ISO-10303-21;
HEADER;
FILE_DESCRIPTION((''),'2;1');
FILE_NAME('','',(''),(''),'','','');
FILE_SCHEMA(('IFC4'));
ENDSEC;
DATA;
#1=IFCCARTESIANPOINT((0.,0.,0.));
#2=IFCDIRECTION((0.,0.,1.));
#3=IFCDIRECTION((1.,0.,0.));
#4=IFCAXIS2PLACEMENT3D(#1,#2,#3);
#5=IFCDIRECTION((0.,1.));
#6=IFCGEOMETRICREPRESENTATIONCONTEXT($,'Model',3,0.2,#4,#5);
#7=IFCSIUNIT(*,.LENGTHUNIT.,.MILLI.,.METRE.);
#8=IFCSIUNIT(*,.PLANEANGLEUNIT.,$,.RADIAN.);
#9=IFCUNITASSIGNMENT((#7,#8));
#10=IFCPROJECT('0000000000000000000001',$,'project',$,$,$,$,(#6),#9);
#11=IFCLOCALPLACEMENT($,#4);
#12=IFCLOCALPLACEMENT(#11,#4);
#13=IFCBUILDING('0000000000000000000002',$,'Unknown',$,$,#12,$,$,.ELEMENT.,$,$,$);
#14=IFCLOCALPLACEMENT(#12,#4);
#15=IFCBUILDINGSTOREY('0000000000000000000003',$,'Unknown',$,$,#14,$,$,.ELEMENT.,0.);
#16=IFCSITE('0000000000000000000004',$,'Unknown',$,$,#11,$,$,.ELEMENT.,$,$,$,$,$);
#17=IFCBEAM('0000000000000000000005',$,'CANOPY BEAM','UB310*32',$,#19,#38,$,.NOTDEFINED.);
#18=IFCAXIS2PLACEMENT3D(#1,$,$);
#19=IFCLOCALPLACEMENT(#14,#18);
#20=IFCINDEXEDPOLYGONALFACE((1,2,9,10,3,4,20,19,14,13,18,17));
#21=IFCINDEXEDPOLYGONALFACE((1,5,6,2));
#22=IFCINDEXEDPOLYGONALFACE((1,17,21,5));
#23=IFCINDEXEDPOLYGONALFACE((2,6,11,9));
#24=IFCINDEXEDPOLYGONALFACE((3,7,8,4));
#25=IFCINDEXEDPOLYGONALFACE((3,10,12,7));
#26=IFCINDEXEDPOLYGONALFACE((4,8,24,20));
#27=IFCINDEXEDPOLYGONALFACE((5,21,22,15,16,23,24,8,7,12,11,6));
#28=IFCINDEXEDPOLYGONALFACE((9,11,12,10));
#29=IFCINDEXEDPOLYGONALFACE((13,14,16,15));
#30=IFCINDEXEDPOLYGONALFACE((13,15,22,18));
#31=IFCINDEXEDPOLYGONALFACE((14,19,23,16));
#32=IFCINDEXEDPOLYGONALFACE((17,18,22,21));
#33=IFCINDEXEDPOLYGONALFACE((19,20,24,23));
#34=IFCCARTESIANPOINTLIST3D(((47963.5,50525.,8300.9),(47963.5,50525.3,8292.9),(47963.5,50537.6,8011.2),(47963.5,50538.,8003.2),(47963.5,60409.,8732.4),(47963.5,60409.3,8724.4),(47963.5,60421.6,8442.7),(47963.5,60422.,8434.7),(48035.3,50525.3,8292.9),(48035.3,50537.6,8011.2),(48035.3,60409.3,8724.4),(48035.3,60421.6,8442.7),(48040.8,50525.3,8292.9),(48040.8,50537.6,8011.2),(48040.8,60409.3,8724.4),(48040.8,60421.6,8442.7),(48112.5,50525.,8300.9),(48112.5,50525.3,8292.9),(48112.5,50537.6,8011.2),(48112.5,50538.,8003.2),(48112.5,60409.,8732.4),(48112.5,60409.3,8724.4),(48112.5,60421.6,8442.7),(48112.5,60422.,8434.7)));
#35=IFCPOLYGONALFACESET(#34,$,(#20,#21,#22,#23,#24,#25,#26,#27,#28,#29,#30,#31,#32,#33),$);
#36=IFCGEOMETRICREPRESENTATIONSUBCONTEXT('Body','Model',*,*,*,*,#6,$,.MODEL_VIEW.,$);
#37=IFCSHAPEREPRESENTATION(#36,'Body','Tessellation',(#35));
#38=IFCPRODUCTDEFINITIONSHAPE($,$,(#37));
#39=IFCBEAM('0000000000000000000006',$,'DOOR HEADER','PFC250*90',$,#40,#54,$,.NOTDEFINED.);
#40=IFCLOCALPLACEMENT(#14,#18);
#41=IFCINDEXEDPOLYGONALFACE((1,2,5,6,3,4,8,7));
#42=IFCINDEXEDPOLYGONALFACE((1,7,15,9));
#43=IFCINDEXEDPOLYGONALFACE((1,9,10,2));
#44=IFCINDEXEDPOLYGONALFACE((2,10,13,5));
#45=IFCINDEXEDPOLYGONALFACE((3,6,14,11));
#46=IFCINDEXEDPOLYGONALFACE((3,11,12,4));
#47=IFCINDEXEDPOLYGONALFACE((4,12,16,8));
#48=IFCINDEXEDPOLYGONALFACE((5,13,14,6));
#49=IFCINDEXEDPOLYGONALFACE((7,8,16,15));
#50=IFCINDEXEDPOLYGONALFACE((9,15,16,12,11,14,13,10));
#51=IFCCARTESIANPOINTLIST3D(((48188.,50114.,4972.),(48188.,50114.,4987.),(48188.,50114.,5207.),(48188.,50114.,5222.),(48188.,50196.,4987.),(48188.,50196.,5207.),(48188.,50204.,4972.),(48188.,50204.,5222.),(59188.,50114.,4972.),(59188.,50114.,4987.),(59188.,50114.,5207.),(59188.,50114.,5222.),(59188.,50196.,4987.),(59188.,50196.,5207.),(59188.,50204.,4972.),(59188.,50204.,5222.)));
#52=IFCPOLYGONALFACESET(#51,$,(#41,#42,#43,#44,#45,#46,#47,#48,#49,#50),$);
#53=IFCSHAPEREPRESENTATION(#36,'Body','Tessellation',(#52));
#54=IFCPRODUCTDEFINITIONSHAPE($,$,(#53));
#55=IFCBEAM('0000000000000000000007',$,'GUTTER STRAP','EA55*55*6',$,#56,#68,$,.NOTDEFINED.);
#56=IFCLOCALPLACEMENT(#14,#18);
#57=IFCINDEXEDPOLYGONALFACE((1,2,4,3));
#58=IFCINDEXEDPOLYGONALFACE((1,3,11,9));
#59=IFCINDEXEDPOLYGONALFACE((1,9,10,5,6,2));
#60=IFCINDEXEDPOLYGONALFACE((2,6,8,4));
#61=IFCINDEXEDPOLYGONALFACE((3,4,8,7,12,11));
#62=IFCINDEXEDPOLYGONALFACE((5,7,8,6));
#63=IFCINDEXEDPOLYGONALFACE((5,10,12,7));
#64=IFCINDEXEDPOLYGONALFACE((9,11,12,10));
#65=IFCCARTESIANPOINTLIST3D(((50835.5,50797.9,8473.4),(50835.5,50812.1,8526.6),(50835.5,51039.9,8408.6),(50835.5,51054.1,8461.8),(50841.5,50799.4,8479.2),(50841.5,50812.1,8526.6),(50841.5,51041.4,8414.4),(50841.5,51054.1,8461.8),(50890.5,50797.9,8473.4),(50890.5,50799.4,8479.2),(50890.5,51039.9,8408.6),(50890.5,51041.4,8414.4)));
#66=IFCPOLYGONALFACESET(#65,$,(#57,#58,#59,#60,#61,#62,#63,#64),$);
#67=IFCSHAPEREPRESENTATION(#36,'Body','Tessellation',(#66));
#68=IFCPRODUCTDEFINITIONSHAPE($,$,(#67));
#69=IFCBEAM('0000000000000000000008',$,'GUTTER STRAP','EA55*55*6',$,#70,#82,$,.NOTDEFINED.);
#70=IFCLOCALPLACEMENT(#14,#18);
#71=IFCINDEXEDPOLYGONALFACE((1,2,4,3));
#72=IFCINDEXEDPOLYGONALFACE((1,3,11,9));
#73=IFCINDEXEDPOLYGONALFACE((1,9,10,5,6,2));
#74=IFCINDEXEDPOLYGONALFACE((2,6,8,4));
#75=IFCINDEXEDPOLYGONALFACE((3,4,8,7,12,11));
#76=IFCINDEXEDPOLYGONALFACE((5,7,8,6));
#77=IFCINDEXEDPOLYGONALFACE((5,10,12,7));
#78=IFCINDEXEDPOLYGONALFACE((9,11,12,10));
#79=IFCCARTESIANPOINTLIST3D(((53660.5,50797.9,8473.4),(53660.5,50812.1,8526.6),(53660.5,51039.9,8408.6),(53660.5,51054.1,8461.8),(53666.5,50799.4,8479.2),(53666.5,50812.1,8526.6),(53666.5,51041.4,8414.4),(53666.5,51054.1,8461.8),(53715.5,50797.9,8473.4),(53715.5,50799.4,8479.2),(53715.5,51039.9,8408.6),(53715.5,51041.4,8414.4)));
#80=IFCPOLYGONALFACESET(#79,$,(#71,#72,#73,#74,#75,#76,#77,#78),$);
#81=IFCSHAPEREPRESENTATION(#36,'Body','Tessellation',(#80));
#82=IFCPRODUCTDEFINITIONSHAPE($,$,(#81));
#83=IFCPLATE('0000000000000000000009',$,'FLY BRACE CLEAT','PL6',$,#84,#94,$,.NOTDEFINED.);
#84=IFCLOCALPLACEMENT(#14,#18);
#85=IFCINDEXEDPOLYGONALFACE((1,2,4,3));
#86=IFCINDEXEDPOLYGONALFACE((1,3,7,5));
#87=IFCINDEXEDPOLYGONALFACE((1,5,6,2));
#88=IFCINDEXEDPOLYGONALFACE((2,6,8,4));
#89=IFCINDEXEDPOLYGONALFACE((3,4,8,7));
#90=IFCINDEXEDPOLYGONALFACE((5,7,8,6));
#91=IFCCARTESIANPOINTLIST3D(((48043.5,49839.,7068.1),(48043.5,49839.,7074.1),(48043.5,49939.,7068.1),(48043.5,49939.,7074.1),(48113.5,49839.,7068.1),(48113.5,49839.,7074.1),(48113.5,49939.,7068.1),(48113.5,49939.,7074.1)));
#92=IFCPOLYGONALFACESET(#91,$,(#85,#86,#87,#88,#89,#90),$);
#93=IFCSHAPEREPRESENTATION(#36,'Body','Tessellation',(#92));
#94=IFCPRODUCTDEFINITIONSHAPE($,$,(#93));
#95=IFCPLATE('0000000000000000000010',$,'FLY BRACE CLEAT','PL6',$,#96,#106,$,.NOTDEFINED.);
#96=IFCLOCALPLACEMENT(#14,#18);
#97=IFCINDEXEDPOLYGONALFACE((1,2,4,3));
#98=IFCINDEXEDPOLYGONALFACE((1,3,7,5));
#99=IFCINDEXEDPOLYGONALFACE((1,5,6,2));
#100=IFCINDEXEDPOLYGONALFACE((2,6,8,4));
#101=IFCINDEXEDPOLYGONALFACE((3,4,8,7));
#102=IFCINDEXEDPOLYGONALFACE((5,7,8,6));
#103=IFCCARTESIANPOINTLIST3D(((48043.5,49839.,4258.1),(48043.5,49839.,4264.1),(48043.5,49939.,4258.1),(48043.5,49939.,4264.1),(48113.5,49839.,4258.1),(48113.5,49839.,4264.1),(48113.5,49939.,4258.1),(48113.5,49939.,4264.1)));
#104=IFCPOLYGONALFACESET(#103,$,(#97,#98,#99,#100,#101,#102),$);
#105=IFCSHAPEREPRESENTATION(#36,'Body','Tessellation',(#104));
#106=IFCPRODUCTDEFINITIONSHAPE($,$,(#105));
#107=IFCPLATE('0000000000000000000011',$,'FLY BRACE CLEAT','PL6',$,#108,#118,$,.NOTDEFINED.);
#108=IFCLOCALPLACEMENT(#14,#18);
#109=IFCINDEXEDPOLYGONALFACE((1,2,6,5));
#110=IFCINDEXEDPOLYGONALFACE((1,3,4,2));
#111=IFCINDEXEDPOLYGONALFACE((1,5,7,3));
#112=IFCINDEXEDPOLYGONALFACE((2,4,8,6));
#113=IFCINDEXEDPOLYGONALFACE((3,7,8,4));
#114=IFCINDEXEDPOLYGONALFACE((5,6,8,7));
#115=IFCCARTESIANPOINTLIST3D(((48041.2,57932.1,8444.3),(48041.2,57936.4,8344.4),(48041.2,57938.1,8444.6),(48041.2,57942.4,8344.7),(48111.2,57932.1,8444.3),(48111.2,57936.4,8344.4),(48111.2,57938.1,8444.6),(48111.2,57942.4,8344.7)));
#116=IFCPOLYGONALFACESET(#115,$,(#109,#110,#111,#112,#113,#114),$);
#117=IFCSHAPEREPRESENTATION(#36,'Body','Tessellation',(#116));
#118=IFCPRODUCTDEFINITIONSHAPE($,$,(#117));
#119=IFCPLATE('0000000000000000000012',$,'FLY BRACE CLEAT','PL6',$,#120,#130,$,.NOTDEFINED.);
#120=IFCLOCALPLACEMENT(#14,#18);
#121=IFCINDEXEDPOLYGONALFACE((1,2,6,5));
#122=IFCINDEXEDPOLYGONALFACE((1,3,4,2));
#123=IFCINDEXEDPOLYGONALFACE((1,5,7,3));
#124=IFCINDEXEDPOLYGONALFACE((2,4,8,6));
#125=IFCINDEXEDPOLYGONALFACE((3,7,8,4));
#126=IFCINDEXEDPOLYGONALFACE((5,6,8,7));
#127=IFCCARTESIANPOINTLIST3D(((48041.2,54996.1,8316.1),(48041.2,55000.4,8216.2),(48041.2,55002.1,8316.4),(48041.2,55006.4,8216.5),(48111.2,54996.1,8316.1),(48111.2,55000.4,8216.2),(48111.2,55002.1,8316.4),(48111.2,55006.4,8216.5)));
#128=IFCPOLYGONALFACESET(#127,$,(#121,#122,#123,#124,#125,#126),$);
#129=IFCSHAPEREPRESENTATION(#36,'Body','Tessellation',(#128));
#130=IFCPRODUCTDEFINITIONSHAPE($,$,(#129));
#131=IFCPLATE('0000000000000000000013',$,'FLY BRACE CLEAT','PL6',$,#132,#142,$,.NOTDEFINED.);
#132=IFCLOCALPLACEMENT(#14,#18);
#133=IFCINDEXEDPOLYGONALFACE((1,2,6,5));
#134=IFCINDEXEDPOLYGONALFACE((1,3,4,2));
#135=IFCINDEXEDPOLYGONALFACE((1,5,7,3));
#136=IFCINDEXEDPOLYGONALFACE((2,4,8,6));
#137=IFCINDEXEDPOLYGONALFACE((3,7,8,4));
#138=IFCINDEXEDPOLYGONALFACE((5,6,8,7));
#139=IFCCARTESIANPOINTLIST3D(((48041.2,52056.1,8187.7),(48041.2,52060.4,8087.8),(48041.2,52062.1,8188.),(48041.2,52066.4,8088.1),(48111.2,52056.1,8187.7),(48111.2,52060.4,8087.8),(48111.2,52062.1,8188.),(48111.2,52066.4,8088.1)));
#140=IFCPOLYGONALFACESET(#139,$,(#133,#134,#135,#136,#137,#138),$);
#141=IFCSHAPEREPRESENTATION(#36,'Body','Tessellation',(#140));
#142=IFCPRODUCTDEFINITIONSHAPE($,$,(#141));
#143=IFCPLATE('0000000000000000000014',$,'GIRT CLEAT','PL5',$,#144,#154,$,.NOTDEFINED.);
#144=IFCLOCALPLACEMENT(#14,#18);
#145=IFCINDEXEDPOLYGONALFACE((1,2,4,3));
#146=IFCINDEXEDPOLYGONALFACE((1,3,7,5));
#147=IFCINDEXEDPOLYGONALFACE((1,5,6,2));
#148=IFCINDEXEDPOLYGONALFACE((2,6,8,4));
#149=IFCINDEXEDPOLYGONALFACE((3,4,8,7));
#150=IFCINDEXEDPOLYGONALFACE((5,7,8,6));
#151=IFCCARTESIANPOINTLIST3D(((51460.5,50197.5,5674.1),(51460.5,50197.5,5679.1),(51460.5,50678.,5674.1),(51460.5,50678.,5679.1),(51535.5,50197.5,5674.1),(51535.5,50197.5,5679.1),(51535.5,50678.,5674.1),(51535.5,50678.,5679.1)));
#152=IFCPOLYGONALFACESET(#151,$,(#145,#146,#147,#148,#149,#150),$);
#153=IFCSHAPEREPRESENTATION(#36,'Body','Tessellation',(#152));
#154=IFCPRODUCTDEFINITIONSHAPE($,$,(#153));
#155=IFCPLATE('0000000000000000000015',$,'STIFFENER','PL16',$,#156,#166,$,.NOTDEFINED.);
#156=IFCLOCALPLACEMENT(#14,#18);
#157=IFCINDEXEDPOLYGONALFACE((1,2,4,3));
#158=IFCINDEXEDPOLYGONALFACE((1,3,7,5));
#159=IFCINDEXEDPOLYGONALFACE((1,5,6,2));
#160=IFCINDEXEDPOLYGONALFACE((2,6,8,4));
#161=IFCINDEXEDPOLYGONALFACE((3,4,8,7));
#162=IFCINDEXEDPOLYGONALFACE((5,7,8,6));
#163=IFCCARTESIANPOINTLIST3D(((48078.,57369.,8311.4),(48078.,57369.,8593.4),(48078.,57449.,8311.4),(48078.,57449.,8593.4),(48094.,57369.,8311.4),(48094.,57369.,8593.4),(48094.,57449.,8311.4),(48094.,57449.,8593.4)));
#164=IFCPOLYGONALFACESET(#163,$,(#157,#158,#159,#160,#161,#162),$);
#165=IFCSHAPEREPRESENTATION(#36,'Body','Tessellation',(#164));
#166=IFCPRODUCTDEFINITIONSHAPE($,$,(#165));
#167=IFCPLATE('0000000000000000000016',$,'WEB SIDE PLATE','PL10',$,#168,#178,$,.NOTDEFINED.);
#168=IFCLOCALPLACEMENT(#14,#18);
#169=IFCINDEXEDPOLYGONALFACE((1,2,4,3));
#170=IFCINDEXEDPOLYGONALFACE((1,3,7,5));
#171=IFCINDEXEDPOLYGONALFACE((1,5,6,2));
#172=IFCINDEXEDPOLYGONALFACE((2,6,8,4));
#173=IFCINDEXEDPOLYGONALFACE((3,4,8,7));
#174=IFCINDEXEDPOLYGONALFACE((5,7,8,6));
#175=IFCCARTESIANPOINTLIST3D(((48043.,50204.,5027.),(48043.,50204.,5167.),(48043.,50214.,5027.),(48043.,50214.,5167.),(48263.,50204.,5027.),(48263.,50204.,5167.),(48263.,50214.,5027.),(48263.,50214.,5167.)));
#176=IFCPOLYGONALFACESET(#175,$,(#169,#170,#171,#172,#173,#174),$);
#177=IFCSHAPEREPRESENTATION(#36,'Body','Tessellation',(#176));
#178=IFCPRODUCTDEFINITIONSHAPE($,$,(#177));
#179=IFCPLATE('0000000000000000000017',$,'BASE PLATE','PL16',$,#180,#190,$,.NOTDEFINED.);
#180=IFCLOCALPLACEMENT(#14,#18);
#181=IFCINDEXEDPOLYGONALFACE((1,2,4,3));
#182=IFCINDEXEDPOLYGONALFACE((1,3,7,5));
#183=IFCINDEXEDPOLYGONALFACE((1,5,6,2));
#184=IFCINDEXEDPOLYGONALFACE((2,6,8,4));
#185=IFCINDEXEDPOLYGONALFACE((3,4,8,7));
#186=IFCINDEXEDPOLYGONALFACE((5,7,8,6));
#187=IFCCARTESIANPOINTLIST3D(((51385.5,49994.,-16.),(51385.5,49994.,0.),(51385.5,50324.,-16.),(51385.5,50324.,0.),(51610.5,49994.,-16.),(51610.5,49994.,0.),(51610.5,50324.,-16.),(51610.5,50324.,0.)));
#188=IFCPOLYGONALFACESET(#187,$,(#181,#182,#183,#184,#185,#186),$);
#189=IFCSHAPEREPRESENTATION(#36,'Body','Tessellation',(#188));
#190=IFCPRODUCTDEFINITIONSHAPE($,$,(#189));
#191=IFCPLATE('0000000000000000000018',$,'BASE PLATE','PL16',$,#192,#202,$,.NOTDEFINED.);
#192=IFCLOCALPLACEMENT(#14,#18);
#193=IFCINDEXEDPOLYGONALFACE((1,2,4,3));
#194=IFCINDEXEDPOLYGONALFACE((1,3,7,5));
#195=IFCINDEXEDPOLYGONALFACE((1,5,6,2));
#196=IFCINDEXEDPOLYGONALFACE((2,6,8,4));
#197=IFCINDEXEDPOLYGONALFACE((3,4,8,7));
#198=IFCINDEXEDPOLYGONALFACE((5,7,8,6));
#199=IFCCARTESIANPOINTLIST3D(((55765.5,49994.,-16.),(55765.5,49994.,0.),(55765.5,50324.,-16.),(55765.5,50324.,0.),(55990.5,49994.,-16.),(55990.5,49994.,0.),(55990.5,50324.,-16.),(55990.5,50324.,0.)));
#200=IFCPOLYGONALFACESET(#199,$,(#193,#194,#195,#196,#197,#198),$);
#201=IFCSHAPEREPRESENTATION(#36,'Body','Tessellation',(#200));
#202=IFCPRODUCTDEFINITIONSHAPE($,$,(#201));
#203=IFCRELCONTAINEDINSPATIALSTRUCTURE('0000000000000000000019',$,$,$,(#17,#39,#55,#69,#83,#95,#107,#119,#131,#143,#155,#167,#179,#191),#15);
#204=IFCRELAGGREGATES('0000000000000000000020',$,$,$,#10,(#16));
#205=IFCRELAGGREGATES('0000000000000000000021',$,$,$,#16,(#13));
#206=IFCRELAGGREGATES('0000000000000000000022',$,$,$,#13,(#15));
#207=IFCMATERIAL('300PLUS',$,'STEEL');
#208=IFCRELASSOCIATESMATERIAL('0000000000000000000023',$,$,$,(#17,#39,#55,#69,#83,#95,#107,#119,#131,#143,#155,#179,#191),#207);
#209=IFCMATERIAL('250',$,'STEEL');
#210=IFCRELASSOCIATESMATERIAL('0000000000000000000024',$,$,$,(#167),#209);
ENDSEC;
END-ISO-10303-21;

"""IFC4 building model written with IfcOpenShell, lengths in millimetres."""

from ifc_helpers import new_model, si_unit, direction, frame, origin_with_axes, place, context, subcontext, project, spatial, line, indexed_curve, outline, extrude, material, element, save


model = new_model("IFC4")

# Units and contexts
model_context = context("Model", 3, precision=0.2, world=origin_with_axes(), true_north=direction((0.0, 1.0)))
body_context = subcontext(model_context, "Body", "Model", "MODEL_VIEW")
ifc_project = project(units=[si_unit("LENGTHUNIT", "METRE", prefix="MILLI"), si_unit("PLANEANGLEUNIT", "RADIAN")], contexts=[model_context])

# Site, building, storey
site_placement = place(None, origin_with_axes())
site = spatial("IfcSite", under=ifc_project, at=site_placement, Name="Unknown", CompositionType="ELEMENT")
building_placement = place(site_placement, origin_with_axes())
building = spatial("IfcBuilding", under=site, at=building_placement, Name="Unknown", CompositionType="ELEMENT")
storey_placement = place(building_placement, origin_with_axes())
storey = spatial("IfcBuildingStorey", under=building, at=storey_placement, Name="Unknown", CompositionType="ELEMENT", Elevation=0.0)

# Shared definitions
ifc_material_1 = material(Name="300PLUS", Category="STEEL")

# Beams
beam_1_placement = place(storey_placement, frame((48038.0, 50531.5, 8152.0), z_axis=(1.0, 0.0, 0.0), x_axis=(0.0, 0.999048, 0.043615)))
element("IfcBeam", 1, at=beam_1_placement, inside=storey, material=ifc_material_1, Name="CANOPY BEAM", Description="UB310*32", PredefinedType="NOTDEFINED", context=body_context, shape_type="SolidModel", body=[
    extrude(outline(indexed_curve([(-74.5, -149.0), (74.5, -149.0), (74.5, -141.0), (2.8, -141.0), (2.8, 141.0), (74.5, 141.0), (74.5, 149.0), (-74.5, 149.0), (-74.5, 141.0), (-2.8, 141.0), (-2.8, -141.0), (-74.5, -141.0)], segments=[line(1, 2, 3, 4, 5, 6, 7, 8, 9, 10, 11, 12, 1)])), frame((0.0, 0.0, 0.0), z_axis=(-1.0, 0.0, 0.0), x_axis=(0.0, 0.0, 1.0)), (0.0, 0.0, -1.0), 9893.4),
])
beam_2_placement = place(storey_placement, frame((48188.0, 50159.0, 5097.0), z_axis=(0.0, -1.0, 0.0), x_axis=(1.0, 0.0, 0.0)))
element("IfcBeam", 2, at=beam_2_placement, inside=storey, material=ifc_material_1, Name="DOOR HEADER", Description="PFC250*90", PredefinedType="NOTDEFINED", context=body_context, shape_type="SolidModel", body=[
    extrude(outline(indexed_curve([(-45.0, -125.0), (45.0, -125.0), (45.0, -110.0), (-37.0, -110.0), (-37.0, 110.0), (45.0, 110.0), (45.0, 125.0), (-45.0, 125.0)], segments=[line(1, 2, 3, 4, 5, 6, 7, 8, 1)])), frame((0.0, 0.0, 0.0), z_axis=(-1.0, 0.0, 0.0), x_axis=(0.0, 0.0, 1.0)), (0.0, 0.0, -1.0), 11000.0),
])
for number, where, z_axis, x_axis, name in (
    (3, (50863.0, 51047.0, 8435.2), (0.0, 0.258656, 0.965969), (0.0, -0.965969, 0.258656), "GUTTER STRAP"),
    (4, (53688.0, 51047.0, 8435.2), (0.0, 0.258656, 0.965969), (0.0, -0.965969, 0.258656), "GUTTER STRAP"),
):
    element("IfcBeam", number, at=place(storey_placement, frame(where, z_axis=z_axis, x_axis=x_axis)), inside=storey, material=ifc_material_1, Name=name, Description="EA55*55*6", PredefinedType="NOTDEFINED", context=body_context, shape_type="SolidModel", body=[
        extrude(outline(indexed_curve([(-27.5, -27.5), (27.5, -27.5), (27.5, -21.5), (-21.5, -21.5), (-21.5, 27.5), (-27.5, 27.5)], segments=[line(1, 2, 3, 4, 5, 6, 1)])), frame((0.0, 0.0, 0.0), z_axis=(-1.0, 0.0, 0.0), x_axis=(0.0, 0.0, 1.0)), (0.0, 0.0, -1.0), 250.5),
    ])

# Plates
for number, where, z_axis, x_axis, name in (
    (5, (48113.5, 49939.0, 7071.1), (0.0, 0.0, 1.0), (-1.0, 0.0, 0.0), "FLY BRACE CLEAT"),
    (6, (48113.5, 49939.0, 4261.1), (0.0, 0.0, 1.0), (-1.0, 0.0, 0.0), "FLY BRACE CLEAT"),
):
    element("IfcPlate", number, at=place(storey_placement, frame(where, z_axis=z_axis, x_axis=x_axis)), inside=storey, material=ifc_material_1, Name=name, Description="PL6", PredefinedType="NOTDEFINED", context=body_context, shape_type="SolidModel", body=[
        extrude(outline(indexed_curve([(0.0, 0.0), (70.0, 0.0), (70.0, 100.0), (0.0, 100.0)], segments=[line(1, 2, 3, 4, 1)])), frame((0.0, 0.0, 3.0), z_axis=(0.0, 0.0, 1.0), x_axis=(1.0, 0.0, 0.0)), (0.0, 0.0, -1.0), 6.0),
    ])
for number, where, z_axis, x_axis, name in (
    (7, (48041.2, 57935.1, 8444.4), (0.0, 0.999075, 0.043003), (1.0, 0.0, 0.0), "FLY BRACE CLEAT"),
    (8, (48041.2, 54999.1, 8316.2), (0.0, 0.999075, 0.043003), (1.0, 0.0, 0.0), "FLY BRACE CLEAT"),
    (9, (48041.2, 52059.1, 8187.8), (0.0, 0.999075, 0.043003), (1.0, 0.0, 0.0), "FLY BRACE CLEAT"),
):
    element("IfcPlate", number, at=place(storey_placement, frame(where, z_axis=z_axis, x_axis=x_axis)), inside=storey, material=ifc_material_1, Name=name, Description="PL6", PredefinedType="NOTDEFINED", context=body_context, shape_type="SolidModel", body=[
        extrude(outline(indexed_curve([(0.0, 0.0), (70.0, 0.0), (70.0, 100.0), (0.0, 100.0)], segments=[line(1, 2, 3, 4, 1)])), frame((0.0, 0.0, 3.0), z_axis=(0.0, 0.0, 1.0), x_axis=(1.0, 0.0, 0.0)), (0.0, 0.0, -1.0), 6.0),
    ])
plate_1_placement = place(storey_placement, frame((51460.5, 50197.5, 5676.6), z_axis=(0.0, 0.0, 1.0), x_axis=(1.0, 0.0, 0.0)))
element("IfcPlate", 10, at=plate_1_placement, inside=storey, material=ifc_material_1, Name="GIRT CLEAT", Description="PL5", PredefinedType="NOTDEFINED", context=body_context, shape_type="SolidModel", body=[
    extrude(outline(indexed_curve([(0.0, 0.0), (75.0, 0.0), (75.0, 480.5), (0.0, 480.5)], segments=[line(1, 2, 3, 4, 1)])), frame((0.0, 0.0, 2.5), z_axis=(0.0, 0.0, 1.0), x_axis=(1.0, 0.0, 0.0)), (0.0, 0.0, -1.0), 5.0),
])
plate_2_placement = place(storey_placement, frame((48086.0, 57369.0, 8311.4), z_axis=(1.0, 0.0, 0.0), x_axis=(0.0, 1.0, 0.0)))
element("IfcPlate", 11, at=plate_2_placement, inside=storey, material=ifc_material_1, Name="STIFFENER", Description="PL16", PredefinedType="NOTDEFINED", context=body_context, shape_type="SolidModel", body=[
    extrude(outline(indexed_curve([(0.0, 0.0), (80.0, 0.0), (80.0, 282.0), (0.0, 282.0)], segments=[line(1, 2, 3, 4, 1)])), frame((0.0, 0.0, 8.0), z_axis=(0.0, 0.0, 1.0), x_axis=(1.0, 0.0, 0.0)), (0.0, 0.0, -1.0), 16.0),
])
ifc_material_2 = material(Name="250", Category="STEEL")
plate_3_placement = place(storey_placement, frame((48263.0, 50209.0, 5167.0), z_axis=(0.0, 1.0, 0.0), x_axis=(0.0, 0.0, -1.0)))
element("IfcPlate", 12, at=plate_3_placement, inside=storey, material=ifc_material_2, Name="WEB SIDE PLATE", Description="PL10", PredefinedType="NOTDEFINED", context=body_context, shape_type="SolidModel", body=[
    extrude(outline(indexed_curve([(0.0, 0.0), (140.0, 0.0), (140.0, 220.0), (0.0, 220.0)], segments=[line(1, 2, 3, 4, 1)])), frame((0.0, 0.0, 5.0), z_axis=(0.0, 0.0, 1.0), x_axis=(1.0, 0.0, 0.0)), (0.0, 0.0, -1.0), 10.0),
])
for number, where, z_axis, x_axis, name in (
    (13, (51385.5, 49994.0, -8.0), (0.0, 0.0, 1.0), (1.0, 0.0, 0.0), "BASE PLATE"),
    (14, (55765.5, 49994.0, -8.0), (0.0, 0.0, 1.0), (1.0, 0.0, 0.0), "BASE PLATE"),
):
    element("IfcPlate", number, at=place(storey_placement, frame(where, z_axis=z_axis, x_axis=x_axis)), inside=storey, material=ifc_material_1, Name=name, Description="PL16", PredefinedType="NOTDEFINED", context=body_context, shape_type="SolidModel", body=[
        extrude(outline(indexed_curve([(0.0, 0.0), (225.0, 0.0), (225.0, 330.0), (0.0, 330.0)], segments=[line(1, 2, 3, 4, 1)])), frame((0.0, 0.0, 8.0), z_axis=(0.0, 0.0, 1.0), x_axis=(1.0, 0.0, 0.0)), (0.0, 0.0, -1.0), 16.0),
    ])

save(model, "model.ifc")
